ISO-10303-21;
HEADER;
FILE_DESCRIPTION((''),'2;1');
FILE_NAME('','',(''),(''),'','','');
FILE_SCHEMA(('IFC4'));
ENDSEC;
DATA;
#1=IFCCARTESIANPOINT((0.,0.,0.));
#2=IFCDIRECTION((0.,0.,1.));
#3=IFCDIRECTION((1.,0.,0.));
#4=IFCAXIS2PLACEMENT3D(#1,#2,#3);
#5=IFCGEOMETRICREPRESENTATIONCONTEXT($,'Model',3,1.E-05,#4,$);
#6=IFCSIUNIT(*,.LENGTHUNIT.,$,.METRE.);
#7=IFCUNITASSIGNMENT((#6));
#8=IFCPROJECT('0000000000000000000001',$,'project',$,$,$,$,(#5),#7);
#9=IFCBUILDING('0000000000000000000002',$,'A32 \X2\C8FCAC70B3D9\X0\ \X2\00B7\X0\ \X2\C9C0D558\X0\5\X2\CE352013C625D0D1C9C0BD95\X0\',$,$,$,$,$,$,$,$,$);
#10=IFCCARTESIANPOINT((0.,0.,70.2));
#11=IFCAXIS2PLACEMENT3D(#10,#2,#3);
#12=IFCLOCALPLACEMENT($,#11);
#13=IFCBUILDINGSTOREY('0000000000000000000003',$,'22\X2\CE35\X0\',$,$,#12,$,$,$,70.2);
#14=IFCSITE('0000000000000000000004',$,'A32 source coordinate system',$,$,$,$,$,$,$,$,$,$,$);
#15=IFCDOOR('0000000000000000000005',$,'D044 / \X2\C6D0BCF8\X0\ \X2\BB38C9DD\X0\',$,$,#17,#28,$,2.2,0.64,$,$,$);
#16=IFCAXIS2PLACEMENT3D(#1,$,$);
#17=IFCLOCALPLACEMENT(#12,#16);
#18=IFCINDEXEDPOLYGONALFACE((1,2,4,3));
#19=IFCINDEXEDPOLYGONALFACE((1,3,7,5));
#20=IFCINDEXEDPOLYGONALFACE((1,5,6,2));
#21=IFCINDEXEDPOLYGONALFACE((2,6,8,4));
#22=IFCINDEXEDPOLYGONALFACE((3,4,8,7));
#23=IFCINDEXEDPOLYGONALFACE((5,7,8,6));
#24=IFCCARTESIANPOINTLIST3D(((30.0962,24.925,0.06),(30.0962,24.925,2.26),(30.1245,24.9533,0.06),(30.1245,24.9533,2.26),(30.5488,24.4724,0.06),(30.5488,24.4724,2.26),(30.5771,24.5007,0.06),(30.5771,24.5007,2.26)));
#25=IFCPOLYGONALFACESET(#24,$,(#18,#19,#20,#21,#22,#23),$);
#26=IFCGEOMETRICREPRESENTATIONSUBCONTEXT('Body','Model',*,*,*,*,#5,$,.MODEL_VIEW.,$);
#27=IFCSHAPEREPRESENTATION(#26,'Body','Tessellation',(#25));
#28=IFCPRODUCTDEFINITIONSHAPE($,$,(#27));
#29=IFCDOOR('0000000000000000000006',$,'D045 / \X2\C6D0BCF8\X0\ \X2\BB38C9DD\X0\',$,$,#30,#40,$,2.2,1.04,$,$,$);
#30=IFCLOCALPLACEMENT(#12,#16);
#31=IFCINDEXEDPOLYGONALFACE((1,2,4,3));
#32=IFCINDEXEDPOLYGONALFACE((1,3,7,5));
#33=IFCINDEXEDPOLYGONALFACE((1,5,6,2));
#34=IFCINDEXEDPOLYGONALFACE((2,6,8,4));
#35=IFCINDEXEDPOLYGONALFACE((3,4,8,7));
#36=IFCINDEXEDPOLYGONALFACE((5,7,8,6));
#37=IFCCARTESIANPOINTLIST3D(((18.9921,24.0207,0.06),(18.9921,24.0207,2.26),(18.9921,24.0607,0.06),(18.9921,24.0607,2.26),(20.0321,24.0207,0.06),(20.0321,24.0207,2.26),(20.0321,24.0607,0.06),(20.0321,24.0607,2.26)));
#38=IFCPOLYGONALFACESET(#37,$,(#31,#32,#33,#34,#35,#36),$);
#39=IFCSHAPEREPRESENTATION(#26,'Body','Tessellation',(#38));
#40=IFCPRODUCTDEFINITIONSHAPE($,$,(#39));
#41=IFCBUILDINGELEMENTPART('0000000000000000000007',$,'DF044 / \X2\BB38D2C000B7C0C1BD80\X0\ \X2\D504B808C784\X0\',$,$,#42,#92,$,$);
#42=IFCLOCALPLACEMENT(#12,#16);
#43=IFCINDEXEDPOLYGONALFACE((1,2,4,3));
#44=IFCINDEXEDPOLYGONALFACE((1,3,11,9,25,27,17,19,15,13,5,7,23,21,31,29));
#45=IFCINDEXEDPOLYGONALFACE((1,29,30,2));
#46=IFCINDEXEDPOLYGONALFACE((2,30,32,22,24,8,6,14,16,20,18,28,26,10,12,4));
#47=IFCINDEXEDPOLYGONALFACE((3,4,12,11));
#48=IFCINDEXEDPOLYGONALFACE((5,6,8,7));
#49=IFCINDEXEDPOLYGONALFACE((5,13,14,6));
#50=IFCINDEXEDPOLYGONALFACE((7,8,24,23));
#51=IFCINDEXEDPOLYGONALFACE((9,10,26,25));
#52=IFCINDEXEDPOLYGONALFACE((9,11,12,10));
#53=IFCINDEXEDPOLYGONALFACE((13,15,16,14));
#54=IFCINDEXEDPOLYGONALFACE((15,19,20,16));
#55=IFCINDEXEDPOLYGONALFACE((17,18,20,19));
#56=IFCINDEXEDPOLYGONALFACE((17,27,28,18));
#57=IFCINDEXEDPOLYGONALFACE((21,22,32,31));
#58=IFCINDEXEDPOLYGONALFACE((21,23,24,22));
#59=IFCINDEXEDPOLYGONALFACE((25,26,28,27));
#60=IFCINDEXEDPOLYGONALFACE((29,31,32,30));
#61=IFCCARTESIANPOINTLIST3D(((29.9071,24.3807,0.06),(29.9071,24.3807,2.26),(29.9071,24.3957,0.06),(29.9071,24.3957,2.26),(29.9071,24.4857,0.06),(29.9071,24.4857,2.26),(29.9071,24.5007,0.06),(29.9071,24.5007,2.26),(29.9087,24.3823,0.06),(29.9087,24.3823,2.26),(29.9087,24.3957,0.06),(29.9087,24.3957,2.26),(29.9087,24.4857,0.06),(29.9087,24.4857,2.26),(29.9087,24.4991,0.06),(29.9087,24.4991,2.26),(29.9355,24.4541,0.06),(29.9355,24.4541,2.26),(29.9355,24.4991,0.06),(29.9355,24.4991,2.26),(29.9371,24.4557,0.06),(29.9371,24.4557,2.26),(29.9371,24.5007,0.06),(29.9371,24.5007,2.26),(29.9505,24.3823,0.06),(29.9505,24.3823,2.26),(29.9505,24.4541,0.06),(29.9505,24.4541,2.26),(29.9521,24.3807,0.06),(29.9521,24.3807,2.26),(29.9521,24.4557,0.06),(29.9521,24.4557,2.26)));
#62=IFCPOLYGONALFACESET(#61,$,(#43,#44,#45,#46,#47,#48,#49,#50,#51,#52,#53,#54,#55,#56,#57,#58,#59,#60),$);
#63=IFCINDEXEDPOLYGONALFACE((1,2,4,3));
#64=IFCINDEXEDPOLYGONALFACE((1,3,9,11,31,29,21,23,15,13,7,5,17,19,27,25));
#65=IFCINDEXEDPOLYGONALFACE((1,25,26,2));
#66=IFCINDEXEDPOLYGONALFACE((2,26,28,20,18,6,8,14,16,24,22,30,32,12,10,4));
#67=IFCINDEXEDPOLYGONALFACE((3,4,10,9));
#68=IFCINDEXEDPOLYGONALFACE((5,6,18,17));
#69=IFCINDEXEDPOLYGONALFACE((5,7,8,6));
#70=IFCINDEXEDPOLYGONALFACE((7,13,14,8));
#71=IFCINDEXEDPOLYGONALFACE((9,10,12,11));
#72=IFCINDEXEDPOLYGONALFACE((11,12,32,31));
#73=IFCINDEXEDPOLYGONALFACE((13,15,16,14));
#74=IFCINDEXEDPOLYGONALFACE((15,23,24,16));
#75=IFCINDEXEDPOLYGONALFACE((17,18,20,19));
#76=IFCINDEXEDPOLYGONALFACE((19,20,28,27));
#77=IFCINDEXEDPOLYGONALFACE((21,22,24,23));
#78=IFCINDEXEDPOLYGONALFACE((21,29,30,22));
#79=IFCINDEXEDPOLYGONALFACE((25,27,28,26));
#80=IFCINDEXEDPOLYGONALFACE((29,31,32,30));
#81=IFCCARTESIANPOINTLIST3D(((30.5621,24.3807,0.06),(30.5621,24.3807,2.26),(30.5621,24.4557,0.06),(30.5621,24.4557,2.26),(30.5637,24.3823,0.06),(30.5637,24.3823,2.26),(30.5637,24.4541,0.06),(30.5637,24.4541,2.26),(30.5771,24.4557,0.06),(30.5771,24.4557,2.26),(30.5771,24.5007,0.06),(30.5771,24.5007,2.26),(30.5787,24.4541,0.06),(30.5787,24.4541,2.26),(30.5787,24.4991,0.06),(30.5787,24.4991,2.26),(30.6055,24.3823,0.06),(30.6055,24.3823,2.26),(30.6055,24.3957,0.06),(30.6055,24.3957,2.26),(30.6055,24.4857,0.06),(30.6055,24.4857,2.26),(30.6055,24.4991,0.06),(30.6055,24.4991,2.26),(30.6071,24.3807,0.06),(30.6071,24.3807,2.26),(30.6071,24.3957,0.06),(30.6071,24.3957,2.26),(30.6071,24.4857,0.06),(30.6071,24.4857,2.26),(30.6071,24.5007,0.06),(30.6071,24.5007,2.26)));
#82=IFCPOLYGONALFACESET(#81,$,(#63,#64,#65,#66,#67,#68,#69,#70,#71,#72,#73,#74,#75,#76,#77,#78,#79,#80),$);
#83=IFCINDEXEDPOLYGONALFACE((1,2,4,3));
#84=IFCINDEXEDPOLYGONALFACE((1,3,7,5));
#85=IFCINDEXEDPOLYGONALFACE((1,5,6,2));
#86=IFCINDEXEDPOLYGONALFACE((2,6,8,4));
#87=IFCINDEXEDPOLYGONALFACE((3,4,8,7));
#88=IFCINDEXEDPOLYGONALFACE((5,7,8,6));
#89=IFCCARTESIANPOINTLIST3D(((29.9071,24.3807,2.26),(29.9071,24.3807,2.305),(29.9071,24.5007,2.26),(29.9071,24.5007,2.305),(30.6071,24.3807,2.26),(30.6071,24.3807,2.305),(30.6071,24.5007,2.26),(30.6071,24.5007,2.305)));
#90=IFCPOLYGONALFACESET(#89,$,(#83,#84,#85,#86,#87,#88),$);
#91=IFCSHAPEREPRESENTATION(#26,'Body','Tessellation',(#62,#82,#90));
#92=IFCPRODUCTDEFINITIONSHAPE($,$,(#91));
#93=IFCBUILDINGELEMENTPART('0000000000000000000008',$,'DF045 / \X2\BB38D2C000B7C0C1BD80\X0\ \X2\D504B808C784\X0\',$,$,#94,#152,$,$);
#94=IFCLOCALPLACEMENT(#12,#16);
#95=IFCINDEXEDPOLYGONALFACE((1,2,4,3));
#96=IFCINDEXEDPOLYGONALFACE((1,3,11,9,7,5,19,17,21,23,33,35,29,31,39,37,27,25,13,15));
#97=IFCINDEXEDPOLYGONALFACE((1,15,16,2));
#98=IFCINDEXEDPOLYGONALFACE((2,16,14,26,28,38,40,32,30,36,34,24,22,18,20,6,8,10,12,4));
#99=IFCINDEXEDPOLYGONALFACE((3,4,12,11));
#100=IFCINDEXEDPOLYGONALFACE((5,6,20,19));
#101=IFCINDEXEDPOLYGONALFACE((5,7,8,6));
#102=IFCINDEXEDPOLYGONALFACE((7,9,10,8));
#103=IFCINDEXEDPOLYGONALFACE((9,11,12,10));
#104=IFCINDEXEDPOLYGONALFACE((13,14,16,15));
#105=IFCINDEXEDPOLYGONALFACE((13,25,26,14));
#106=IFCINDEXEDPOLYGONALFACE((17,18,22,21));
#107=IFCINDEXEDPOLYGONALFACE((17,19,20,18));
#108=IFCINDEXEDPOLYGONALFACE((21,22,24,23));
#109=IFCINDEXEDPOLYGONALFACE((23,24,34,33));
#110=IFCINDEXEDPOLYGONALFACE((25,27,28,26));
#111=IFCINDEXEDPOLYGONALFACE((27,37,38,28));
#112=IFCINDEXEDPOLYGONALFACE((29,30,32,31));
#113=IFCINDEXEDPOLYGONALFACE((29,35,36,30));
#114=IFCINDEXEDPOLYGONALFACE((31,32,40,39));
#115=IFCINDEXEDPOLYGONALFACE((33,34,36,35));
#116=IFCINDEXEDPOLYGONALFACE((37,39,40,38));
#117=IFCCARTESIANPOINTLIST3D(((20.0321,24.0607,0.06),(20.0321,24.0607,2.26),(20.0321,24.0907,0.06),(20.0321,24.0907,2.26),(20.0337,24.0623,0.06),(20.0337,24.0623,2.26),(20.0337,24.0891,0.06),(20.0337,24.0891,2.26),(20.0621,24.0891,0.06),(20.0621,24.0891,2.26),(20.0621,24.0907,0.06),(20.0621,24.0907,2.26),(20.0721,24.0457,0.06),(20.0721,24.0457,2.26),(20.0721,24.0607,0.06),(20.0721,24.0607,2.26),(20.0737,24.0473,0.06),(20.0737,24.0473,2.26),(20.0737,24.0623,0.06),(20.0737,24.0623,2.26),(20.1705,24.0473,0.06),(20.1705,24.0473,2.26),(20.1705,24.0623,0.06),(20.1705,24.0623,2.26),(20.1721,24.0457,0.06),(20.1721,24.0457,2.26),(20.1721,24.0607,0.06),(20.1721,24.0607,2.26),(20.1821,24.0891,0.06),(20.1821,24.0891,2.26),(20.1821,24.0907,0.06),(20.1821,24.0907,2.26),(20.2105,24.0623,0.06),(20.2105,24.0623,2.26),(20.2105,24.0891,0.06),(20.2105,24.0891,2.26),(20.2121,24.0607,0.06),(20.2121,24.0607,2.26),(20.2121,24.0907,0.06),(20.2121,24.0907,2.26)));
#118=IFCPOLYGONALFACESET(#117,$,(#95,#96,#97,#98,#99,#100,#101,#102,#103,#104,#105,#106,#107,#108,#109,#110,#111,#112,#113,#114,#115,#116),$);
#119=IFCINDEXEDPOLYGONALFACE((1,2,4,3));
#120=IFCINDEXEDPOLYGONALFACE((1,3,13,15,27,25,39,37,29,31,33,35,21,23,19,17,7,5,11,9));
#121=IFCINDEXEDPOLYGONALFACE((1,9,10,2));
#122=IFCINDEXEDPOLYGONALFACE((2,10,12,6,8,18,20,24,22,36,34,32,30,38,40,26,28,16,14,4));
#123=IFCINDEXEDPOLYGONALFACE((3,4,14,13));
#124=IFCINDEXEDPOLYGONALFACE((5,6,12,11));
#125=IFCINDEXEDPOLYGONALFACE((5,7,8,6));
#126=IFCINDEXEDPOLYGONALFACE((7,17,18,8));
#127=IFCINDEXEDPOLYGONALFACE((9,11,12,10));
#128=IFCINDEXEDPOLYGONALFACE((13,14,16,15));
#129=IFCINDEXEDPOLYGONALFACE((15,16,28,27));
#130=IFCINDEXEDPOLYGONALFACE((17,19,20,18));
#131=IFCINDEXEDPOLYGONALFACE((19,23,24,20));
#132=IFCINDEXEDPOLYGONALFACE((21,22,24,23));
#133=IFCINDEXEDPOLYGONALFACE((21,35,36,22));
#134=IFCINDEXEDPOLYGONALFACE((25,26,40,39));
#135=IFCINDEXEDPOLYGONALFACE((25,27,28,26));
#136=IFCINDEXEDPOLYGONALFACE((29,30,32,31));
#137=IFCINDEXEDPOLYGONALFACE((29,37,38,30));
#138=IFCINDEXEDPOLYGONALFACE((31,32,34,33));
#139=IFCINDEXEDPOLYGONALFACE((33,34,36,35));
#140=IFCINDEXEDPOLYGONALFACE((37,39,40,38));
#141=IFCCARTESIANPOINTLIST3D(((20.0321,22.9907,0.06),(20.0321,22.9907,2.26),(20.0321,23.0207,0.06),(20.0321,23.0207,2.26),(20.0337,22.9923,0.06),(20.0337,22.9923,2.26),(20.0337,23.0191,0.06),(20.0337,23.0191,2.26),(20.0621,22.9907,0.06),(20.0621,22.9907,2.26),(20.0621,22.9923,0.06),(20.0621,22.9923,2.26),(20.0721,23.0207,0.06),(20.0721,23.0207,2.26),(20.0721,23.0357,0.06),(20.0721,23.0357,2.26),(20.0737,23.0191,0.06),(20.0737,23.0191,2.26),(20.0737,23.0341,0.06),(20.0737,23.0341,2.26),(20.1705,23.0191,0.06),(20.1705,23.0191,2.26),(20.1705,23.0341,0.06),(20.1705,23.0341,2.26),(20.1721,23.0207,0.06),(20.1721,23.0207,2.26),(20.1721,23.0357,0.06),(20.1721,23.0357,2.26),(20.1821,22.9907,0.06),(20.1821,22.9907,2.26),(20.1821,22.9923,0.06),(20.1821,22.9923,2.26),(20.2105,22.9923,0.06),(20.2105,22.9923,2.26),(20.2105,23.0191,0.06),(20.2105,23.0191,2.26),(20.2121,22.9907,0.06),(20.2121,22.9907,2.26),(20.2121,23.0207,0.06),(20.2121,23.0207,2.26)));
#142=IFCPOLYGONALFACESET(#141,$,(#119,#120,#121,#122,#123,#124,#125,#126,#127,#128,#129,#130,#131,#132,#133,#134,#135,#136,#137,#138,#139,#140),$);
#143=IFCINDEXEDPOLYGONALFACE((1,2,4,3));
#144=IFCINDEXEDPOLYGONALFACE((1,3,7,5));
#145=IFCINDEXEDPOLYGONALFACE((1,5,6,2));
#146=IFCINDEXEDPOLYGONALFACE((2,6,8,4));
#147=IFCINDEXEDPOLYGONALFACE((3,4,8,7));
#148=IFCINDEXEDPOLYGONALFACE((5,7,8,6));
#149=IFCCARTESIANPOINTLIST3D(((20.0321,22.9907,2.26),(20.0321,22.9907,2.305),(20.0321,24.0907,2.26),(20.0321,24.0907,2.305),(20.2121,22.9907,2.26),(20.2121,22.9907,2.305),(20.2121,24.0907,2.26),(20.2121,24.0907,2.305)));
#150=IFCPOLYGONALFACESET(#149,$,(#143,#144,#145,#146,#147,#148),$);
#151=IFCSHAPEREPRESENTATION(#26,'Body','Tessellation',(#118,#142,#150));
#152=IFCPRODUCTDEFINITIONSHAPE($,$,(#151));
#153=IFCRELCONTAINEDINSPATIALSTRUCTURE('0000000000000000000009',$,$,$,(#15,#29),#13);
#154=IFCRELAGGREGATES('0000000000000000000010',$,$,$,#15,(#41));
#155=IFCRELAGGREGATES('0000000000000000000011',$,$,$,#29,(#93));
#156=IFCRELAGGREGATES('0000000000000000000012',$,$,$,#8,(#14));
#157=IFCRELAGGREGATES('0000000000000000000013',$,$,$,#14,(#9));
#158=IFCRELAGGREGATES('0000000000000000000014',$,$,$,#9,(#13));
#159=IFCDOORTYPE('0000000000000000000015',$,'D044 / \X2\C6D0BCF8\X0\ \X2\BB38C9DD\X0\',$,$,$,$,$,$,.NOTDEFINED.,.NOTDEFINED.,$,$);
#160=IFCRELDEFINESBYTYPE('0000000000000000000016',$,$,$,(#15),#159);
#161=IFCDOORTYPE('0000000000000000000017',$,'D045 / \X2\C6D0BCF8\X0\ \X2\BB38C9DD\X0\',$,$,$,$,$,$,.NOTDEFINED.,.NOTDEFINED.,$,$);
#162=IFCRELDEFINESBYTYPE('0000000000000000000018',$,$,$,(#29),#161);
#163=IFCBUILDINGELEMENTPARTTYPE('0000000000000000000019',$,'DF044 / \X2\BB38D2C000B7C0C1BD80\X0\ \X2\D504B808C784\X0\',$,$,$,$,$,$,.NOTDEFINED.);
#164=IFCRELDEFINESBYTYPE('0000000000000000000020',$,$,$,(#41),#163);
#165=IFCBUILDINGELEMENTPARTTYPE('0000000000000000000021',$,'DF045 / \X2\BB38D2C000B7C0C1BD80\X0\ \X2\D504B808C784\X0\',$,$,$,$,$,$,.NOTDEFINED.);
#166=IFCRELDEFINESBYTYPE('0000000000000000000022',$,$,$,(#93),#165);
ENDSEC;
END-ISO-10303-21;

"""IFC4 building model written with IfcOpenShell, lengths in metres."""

from ifc_helpers import new_model, si_unit, frame, origin, origin_with_axes, place, context, subcontext, project, spatial, polyline, outline, extrude, source, transform, mapped, type_object, type_shapes, element, aggregate, save


model = new_model("IFC4")

# Units and contexts
model_context = context("Model", 3, precision=1e-05, world=origin_with_axes())
body_context = subcontext(model_context, "Body", "Model", "MODEL_VIEW")
ifc_project = project(units=[si_unit("LENGTHUNIT", "METRE")], contexts=[model_context])

# Site, building, storey
storey_placement = place(None, frame((0.0, 0.0, 70.2), z_axis=(0.0, 0.0, 1.0), x_axis=(1.0, 0.0, 0.0)))
site = spatial("IfcSite", under=ifc_project, Name="A32 source coordinate system")
building = spatial("IfcBuilding", under=site, Name="A32 주거동 · 지하5층–옥탑지붕")
storey = spatial("IfcBuildingStorey", under=building, at=storey_placement, Name="22층", Elevation=70.2)

# Doors
door_type_1 = type_object("IfcDoorType", Name="D044 / 원본 문짝", OperationType="NOTDEFINED", PredefinedType="NOTDEFINED")
shared_shape_1 = source(origin(), body_context, "Body", "SweptSolid", [
    extrude(outline(polyline([(30.5771, 24.5007), (30.5488, 24.4724), (30.0962, 24.925), (30.1245, 24.9533), (30.5771, 24.5007)])), frame((0.0, 0.0, 0.06)), (0.0, 0.0, 1.0), 2.2),
])
type_shapes(door_type_1, [shared_shape_1])
door_1_placement = place(storey_placement, origin_with_axes())
door_1 = element("IfcDoor", 1, at=door_1_placement, inside=storey, type_object=door_type_1, Name="D044 / 원본 문짝", OverallHeight=2.2, OverallWidth=0.64, context=body_context, shape_type="MappedRepresentation", body=[
    mapped(shared_shape_1, transform((0.0, 0.0, 0.0), scale=1.0)),
])
door_type_2 = type_object("IfcDoorType", Name="D045 / 원본 문짝", OperationType="NOTDEFINED", PredefinedType="NOTDEFINED")
shared_shape_2 = source(origin(), body_context, "Body", "SweptSolid", [
    extrude(outline(polyline([(20.0321, 24.0607), (20.0321, 24.0207), (18.9921, 24.0207), (18.9921, 24.0607), (20.0321, 24.0607)])), frame((0.0, 0.0, 0.06)), (0.0, 0.0, 1.0), 2.2),
])
type_shapes(door_type_2, [shared_shape_2])
door_2_placement = place(storey_placement, origin_with_axes())
door_2 = element("IfcDoor", 2, at=door_2_placement, inside=storey, type_object=door_type_2, Name="D045 / 원본 문짝", OverallHeight=2.2, OverallWidth=1.04, context=body_context, shape_type="MappedRepresentation", body=[
    mapped(shared_shape_2, transform((0.0, 0.0, 0.0), scale=1.0)),
])

# Building element parts
building_element_part_type_1 = type_object("IfcBuildingElementPartType", Name="DF044 / 문틀·상부 프레임", PredefinedType="NOTDEFINED")
shared_shape_3 = source(origin(), body_context, "Body", "SweptSolid", [
    extrude(outline(polyline([(29.9071, 24.4857), (29.9071, 24.5007), (29.9371, 24.5007), (29.9371, 24.4557), (29.9521, 24.4557), (29.9521, 24.3807), (29.9071, 24.3807), (29.9071, 24.3957), (29.9087, 24.3957), (29.9087, 24.3823), (29.9505, 24.3823), (29.9505, 24.4541), (29.9355, 24.4541), (29.9355, 24.4991), (29.9087, 24.4991), (29.9087, 24.4857), (29.9071, 24.4857)])), frame((0.0, 0.0, 0.06)), (0.0, 0.0, 1.0), 2.2),
    extrude(outline(polyline([(30.6055, 24.4991), (30.5787, 24.4991), (30.5787, 24.4541), (30.5637, 24.4541), (30.5637, 24.3823), (30.6055, 24.3823), (30.6055, 24.3957), (30.6071, 24.3957), (30.6071, 24.3807), (30.5621, 24.3807), (30.5621, 24.4557), (30.5771, 24.4557), (30.5771, 24.5007), (30.6071, 24.5007), (30.6071, 24.4857), (30.6055, 24.4857), (30.6055, 24.4991)])), frame((0.0, 0.0, 0.06)), (0.0, 0.0, 1.0), 2.2),
    extrude(outline(polyline([(29.9071, 24.3807), (29.9071, 24.5007), (30.6071, 24.5007), (30.6071, 24.3807), (29.9071, 24.3807)])), frame((0.0, 0.0, 2.26)), (0.0, 0.0, 1.0), 0.045),
])
type_shapes(building_element_part_type_1, [shared_shape_3])
building_element_part_1_placement = place(door_1_placement, origin_with_axes())
building_element_part_1 = element("IfcBuildingElementPart", 3, at=building_element_part_1_placement, type_object=building_element_part_type_1, Name="DF044 / 문틀·상부 프레임", context=body_context, shape_type="MappedRepresentation", body=[
    mapped(shared_shape_3, transform((0.0, 0.0, 0.0), scale=1.0)),
])
aggregate(door_1, [building_element_part_1])
building_element_part_type_2 = type_object("IfcBuildingElementPartType", Name="DF045 / 문틀·상부 프레임", PredefinedType="NOTDEFINED")
shared_shape_4 = source(origin(), body_context, "Body", "SweptSolid", [
    extrude(outline(polyline([(20.0337, 24.0891), (20.0337, 24.0623), (20.0737, 24.0623), (20.0737, 24.0473), (20.1705, 24.0473), (20.1705, 24.0623), (20.2105, 24.0623), (20.2105, 24.0891), (20.1821, 24.0891), (20.1821, 24.0907), (20.2121, 24.0907), (20.2121, 24.0607), (20.1721, 24.0607), (20.1721, 24.0457), (20.0721, 24.0457), (20.0721, 24.0607), (20.0321, 24.0607), (20.0321, 24.0907), (20.0621, 24.0907), (20.0621, 24.0891), (20.0337, 24.0891)])), frame((0.0, 0.0, 0.06)), (0.0, 0.0, 1.0), 2.2),
    extrude(outline(polyline([(20.0621, 22.9907), (20.0321, 22.9907), (20.0321, 23.0207), (20.0721, 23.0207), (20.0721, 23.0357), (20.1721, 23.0357), (20.1721, 23.0207), (20.2121, 23.0207), (20.2121, 22.9907), (20.1821, 22.9907), (20.1821, 22.9923), (20.2105, 22.9923), (20.2105, 23.0191), (20.1705, 23.0191), (20.1705, 23.0341), (20.0737, 23.0341), (20.0737, 23.0191), (20.0337, 23.0191), (20.0337, 22.9923), (20.0621, 22.9923), (20.0621, 22.9907)])), frame((0.0, 0.0, 0.06)), (0.0, 0.0, 1.0), 2.2),
    extrude(outline(polyline([(20.0321, 22.9907), (20.0321, 24.0907), (20.2121, 24.0907), (20.2121, 22.9907), (20.0321, 22.9907)])), frame((0.0, 0.0, 2.26)), (0.0, 0.0, 1.0), 0.045),
])
type_shapes(building_element_part_type_2, [shared_shape_4])
building_element_part_2_placement = place(door_2_placement, origin_with_axes())
building_element_part_2 = element("IfcBuildingElementPart", 4, at=building_element_part_2_placement, type_object=building_element_part_type_2, Name="DF045 / 문틀·상부 프레임", context=body_context, shape_type="MappedRepresentation", body=[
    mapped(shared_shape_4, transform((0.0, 0.0, 0.0), scale=1.0)),
])
aggregate(door_2, [building_element_part_2])

save(model, "model.ifc")
